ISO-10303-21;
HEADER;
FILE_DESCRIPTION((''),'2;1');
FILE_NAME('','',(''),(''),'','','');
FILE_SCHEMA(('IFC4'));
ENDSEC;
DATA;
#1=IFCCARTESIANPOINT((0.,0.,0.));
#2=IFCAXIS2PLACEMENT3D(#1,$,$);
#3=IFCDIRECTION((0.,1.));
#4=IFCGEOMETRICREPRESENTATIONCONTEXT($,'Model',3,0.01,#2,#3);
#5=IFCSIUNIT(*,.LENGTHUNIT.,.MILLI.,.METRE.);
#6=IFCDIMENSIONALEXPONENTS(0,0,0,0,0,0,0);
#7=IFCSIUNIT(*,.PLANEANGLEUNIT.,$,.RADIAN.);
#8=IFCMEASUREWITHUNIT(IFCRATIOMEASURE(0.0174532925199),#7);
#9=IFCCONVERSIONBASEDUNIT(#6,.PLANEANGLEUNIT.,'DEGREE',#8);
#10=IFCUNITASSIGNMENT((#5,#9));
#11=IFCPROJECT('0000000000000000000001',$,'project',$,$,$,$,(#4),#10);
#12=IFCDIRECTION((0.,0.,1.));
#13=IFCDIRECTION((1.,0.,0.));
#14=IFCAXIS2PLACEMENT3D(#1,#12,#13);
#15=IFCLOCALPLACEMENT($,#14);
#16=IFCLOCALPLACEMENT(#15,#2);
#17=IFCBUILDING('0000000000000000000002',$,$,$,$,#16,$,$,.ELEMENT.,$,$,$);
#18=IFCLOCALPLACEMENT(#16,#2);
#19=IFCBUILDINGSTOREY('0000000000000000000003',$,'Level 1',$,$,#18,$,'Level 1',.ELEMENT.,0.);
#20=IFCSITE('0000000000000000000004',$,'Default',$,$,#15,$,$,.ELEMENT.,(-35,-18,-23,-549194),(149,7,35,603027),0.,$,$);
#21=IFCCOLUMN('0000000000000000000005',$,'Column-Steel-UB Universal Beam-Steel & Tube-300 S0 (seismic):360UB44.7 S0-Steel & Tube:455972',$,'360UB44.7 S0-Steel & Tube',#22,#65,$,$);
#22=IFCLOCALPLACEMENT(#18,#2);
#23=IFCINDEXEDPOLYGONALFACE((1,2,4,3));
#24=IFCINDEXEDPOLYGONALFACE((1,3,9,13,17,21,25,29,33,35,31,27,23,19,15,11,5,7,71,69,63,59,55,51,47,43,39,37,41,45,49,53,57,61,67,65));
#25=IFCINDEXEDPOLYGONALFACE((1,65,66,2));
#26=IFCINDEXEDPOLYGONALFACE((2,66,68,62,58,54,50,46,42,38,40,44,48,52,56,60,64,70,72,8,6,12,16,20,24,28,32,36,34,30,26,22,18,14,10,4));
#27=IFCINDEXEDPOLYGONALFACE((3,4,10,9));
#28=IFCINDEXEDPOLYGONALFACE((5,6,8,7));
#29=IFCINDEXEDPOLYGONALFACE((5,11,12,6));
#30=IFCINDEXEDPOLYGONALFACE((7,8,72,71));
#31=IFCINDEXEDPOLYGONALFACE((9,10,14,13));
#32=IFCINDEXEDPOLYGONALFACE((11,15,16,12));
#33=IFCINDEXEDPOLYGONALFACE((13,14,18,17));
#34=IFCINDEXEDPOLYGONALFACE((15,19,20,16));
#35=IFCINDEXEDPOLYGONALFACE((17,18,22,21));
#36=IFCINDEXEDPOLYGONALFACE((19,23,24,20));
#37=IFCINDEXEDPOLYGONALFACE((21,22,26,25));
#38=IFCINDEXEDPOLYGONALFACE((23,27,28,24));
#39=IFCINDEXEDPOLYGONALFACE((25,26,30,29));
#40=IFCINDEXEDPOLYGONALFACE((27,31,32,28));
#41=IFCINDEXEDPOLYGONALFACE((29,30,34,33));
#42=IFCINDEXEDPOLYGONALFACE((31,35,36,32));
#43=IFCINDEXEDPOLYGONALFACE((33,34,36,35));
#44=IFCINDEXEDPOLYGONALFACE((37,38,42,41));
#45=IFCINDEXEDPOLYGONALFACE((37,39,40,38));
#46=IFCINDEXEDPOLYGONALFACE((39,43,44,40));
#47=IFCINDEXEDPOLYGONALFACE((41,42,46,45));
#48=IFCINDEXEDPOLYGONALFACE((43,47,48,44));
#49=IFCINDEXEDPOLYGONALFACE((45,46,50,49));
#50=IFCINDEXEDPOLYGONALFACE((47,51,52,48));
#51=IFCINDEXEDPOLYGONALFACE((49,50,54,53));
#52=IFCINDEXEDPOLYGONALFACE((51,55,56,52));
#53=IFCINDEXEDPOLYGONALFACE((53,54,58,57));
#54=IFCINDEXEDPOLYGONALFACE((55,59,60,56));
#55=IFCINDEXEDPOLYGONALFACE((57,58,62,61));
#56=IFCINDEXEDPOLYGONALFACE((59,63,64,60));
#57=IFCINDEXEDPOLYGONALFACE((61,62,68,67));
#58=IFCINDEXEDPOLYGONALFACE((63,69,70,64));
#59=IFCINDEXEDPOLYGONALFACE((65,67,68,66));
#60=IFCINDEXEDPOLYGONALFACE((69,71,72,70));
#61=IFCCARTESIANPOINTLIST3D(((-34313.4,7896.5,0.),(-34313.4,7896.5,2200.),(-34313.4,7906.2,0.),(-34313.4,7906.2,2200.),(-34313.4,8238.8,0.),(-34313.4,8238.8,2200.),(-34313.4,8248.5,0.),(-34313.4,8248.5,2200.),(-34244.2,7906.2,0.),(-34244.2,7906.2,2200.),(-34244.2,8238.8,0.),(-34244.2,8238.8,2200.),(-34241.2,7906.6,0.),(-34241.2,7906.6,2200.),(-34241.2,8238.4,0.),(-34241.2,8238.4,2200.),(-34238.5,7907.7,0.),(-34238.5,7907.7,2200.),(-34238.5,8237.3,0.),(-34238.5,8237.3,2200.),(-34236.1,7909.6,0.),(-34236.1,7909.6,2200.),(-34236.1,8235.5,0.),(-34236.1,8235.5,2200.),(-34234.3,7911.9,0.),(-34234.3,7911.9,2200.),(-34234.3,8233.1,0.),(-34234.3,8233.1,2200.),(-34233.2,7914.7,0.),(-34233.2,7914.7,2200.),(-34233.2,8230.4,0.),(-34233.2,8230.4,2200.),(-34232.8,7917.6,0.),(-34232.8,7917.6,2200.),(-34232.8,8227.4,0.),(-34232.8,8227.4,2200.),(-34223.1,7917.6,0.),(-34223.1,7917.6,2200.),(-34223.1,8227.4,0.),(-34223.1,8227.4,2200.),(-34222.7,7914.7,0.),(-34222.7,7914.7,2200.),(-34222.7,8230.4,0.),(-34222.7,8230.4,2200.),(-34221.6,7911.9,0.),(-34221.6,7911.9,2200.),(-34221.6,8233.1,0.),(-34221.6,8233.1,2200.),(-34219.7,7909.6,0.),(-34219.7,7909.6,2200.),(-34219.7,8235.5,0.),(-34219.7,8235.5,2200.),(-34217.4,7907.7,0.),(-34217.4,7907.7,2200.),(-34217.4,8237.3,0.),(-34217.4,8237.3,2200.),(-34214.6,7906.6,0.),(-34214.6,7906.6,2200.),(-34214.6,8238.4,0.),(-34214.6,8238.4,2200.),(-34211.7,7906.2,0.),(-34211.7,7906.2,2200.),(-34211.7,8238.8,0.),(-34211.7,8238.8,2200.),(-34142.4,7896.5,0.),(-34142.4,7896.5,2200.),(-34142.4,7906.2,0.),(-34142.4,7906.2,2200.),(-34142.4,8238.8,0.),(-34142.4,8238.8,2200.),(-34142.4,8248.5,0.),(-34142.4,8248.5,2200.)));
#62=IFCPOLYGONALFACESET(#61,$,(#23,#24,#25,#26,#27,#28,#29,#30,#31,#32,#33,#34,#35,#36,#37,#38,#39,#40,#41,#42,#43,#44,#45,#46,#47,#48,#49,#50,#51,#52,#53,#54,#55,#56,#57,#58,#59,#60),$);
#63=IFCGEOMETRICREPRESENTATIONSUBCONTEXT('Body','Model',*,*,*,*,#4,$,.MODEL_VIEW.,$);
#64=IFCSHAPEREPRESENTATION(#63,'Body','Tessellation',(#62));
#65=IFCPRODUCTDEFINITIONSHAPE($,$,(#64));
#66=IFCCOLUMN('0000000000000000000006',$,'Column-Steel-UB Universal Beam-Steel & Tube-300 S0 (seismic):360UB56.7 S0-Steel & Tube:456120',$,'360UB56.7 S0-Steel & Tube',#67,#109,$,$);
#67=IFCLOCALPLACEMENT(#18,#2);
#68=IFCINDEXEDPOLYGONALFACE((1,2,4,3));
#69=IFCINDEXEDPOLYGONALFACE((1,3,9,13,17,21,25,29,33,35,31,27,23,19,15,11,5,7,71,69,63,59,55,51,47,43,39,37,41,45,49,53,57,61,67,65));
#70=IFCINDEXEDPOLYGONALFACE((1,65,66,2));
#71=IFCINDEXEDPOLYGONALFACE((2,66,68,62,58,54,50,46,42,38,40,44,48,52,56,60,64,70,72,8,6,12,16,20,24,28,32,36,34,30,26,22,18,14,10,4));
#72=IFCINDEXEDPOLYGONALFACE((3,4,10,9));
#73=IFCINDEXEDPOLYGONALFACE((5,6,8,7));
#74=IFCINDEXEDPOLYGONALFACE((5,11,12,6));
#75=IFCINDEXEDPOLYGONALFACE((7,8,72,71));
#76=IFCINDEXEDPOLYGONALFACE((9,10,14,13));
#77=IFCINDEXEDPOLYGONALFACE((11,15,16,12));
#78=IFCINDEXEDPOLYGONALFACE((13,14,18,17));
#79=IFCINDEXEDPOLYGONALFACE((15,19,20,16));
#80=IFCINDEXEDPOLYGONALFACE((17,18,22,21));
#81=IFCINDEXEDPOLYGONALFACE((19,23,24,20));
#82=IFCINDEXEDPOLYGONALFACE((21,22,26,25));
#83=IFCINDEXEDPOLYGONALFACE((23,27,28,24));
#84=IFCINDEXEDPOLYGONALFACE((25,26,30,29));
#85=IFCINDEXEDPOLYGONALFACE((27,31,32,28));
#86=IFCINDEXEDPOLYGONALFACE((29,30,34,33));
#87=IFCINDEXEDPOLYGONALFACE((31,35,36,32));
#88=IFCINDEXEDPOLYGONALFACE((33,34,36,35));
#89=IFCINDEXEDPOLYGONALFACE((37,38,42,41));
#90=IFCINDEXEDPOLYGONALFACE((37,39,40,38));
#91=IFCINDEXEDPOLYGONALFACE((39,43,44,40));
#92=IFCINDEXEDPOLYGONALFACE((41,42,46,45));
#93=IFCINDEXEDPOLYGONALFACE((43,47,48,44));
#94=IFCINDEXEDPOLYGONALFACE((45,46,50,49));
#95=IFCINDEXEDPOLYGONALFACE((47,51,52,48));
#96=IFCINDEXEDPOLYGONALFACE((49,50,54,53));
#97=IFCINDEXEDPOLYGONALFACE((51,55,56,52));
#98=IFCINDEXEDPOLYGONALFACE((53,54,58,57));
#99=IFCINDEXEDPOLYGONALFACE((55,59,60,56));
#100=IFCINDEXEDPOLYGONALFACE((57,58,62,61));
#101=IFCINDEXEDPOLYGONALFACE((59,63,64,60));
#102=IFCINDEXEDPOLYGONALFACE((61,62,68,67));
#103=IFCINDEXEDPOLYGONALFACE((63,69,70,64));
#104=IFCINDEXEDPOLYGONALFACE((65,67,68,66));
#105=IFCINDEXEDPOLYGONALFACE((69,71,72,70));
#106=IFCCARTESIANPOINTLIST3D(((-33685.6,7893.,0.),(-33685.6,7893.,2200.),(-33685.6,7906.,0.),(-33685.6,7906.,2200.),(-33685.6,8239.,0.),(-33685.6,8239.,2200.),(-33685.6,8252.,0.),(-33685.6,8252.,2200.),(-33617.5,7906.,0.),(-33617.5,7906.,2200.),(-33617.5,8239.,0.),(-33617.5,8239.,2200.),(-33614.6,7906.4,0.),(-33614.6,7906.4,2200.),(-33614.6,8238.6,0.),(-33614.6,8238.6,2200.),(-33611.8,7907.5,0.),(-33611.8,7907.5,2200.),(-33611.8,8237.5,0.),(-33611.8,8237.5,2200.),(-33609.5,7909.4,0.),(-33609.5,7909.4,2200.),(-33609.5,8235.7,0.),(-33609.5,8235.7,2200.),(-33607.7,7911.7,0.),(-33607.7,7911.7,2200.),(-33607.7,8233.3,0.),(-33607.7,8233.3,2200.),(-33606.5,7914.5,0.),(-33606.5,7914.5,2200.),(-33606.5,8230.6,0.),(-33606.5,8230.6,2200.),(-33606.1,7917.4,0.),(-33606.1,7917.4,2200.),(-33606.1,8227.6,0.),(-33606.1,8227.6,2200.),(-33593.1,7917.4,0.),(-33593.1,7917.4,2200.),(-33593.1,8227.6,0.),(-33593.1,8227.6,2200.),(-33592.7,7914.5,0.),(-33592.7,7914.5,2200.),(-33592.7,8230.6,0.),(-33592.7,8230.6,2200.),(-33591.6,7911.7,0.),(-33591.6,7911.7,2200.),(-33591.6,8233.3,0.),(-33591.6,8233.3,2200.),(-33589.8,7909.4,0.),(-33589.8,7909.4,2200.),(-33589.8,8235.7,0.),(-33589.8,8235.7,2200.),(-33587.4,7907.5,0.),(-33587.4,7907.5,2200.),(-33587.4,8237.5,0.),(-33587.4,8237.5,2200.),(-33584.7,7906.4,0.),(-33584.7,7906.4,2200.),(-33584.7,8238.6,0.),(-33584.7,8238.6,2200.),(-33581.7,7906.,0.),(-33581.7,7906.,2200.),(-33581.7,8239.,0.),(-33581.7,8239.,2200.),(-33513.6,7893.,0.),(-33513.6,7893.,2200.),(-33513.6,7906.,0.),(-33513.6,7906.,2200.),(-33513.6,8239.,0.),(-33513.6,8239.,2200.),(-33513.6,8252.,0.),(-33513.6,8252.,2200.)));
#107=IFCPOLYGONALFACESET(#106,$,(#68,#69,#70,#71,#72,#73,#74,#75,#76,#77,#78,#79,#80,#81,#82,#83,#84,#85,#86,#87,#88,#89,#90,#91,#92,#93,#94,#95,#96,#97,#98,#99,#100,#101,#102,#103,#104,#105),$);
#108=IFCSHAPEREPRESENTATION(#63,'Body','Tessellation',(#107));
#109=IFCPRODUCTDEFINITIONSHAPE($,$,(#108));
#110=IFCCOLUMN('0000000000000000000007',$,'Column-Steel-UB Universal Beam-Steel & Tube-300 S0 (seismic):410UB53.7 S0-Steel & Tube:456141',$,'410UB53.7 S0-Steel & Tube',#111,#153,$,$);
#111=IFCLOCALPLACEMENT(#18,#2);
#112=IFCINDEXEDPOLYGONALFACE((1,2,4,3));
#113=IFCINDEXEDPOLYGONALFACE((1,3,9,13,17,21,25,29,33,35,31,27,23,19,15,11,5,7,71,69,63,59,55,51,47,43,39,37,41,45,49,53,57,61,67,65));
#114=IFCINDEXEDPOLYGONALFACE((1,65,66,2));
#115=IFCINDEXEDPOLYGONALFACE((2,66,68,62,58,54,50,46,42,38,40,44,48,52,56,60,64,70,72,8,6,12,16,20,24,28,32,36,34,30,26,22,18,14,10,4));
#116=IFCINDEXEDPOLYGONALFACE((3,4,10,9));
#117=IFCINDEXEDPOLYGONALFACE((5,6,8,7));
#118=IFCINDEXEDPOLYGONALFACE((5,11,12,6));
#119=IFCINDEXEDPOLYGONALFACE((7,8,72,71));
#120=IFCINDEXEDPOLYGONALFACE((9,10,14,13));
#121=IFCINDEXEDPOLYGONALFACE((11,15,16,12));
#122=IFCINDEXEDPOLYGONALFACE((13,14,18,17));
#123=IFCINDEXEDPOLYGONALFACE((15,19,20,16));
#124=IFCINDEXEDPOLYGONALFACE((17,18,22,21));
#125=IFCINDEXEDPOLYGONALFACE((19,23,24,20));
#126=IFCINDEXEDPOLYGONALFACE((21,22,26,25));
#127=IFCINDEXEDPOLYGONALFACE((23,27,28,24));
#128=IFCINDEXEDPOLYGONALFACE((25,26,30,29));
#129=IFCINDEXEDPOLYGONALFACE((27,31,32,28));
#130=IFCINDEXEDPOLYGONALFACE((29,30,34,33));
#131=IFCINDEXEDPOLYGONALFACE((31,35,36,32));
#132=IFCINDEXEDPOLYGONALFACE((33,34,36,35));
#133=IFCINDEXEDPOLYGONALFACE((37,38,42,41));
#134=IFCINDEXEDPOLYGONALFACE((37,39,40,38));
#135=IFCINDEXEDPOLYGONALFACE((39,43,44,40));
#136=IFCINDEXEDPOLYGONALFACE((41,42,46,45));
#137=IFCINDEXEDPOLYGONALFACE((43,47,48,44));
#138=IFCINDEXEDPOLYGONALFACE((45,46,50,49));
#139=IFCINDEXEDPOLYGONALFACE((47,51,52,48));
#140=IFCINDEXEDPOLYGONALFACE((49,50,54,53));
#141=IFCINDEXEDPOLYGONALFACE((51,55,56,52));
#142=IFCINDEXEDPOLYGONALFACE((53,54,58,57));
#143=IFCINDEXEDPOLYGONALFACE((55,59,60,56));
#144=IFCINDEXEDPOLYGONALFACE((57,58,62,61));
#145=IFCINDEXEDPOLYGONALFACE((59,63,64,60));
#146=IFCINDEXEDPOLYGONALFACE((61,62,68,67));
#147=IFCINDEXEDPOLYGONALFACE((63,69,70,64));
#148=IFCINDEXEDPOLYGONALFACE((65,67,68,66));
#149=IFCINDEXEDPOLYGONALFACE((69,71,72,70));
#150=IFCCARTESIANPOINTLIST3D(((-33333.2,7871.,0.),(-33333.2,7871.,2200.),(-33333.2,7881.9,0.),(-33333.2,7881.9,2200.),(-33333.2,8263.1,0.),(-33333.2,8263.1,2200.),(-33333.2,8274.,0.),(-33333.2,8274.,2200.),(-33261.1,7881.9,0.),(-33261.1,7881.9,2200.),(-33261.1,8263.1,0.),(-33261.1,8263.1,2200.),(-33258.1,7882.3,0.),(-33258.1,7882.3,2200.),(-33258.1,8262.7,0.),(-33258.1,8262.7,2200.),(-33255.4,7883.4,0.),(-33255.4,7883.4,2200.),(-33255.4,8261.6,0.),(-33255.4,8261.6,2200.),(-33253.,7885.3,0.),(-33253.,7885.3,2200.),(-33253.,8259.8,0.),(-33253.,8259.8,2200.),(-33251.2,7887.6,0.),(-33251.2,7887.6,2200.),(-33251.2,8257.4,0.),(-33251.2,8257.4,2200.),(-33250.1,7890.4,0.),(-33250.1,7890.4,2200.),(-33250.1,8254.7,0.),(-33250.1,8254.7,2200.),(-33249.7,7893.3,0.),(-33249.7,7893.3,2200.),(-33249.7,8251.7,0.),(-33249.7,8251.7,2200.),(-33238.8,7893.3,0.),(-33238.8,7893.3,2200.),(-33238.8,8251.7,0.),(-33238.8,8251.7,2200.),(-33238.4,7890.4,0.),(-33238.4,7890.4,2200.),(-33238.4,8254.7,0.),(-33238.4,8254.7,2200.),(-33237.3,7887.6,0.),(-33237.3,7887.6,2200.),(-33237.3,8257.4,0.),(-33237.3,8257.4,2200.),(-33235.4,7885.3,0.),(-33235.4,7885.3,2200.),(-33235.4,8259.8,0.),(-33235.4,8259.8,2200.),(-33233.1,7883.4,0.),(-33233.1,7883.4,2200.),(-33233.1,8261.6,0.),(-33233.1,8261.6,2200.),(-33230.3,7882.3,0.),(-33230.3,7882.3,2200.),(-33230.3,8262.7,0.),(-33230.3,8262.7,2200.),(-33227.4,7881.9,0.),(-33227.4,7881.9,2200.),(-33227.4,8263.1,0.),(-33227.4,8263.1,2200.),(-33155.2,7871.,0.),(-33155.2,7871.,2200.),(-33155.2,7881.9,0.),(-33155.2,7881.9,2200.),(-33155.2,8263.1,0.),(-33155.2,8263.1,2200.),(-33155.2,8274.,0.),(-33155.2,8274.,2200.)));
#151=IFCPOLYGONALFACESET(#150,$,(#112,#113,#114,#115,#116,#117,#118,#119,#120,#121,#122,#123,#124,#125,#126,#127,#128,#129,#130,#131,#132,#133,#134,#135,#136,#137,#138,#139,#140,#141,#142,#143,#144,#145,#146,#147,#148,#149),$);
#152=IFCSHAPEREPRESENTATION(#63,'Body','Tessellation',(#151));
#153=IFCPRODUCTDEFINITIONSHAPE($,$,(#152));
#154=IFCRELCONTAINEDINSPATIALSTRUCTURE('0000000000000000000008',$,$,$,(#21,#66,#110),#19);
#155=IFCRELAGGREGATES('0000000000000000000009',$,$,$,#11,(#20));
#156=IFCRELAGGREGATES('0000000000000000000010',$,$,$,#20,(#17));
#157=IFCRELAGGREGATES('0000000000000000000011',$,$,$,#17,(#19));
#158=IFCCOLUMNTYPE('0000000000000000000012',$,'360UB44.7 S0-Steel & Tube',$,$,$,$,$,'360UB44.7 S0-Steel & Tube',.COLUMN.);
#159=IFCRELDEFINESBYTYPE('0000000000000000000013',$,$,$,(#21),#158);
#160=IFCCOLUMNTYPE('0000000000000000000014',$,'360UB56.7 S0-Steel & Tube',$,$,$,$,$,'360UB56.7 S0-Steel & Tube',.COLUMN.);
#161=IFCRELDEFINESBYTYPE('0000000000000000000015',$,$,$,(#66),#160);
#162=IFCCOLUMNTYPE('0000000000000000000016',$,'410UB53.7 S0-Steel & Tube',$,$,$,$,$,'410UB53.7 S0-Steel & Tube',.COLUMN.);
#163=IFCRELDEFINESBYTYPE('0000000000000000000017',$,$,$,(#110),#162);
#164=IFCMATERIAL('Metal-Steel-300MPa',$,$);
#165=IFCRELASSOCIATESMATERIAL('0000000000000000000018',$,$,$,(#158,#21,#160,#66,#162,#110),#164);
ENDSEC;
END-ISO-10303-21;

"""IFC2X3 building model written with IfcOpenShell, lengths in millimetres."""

from ifc_helpers import new_model, entity, si_unit, converted_unit, direction, frame, frame_2d, origin, origin_with_axes, place, context, subcontext, project, spatial, polyline, circle_curve, parameter, trimmed, segment, composite_curve, outline, extrude, source, transform, mapped, material, type_object, type_shapes, element, save


model = new_model("IFC2X3")

# Units and contexts
model_context = context("Model", 3, precision=0.01, world=origin(), true_north=direction((0.0, 1.0)))
body_context = subcontext(model_context, "Body", "Model", "MODEL_VIEW")
ifc_project = project(units=[si_unit("LENGTHUNIT", "METRE", prefix="MILLI"), converted_unit("PLANEANGLEUNIT", "DEGREE", entity("IfcRatioMeasure", 0.0174532925199), si_unit("PLANEANGLEUNIT", "RADIAN"), dimensions=[0, 0, 0, 0, 0, 0, 0])], contexts=[model_context])

# Site, building, storey
site_placement = place(None, origin_with_axes())
site = spatial("IfcSite", under=ifc_project, at=site_placement, Name="Default", CompositionType="ELEMENT", RefLatitude=(-35, -18, -23, -549194), RefLongitude=(149, 7, 35, 603027), RefElevation=0.0)
building_placement = place(site_placement, origin())
building = spatial("IfcBuilding", under=site, at=building_placement, CompositionType="ELEMENT")
storey_placement = place(building_placement, origin())
storey = spatial("IfcBuildingStorey", under=building, at=storey_placement, Name="Level 1", LongName="Level 1", CompositionType="ELEMENT", Elevation=0.0)

# Columns
ifc_material = material(Name="Metal-Steel-300MPa")
column_type_1 = type_object("IfcColumnType", Name="360UB44.7 S0-Steel & Tube", ElementType="360UB44.7 S0-Steel & Tube", PredefinedType="COLUMN", material=ifc_material)
shared_shape_1 = source(origin(), body_context, "Body", "SweptSolid", [
    extrude(outline(composite_curve([segment(polyline([(166.3, -85.5), (176.0, -85.5)]), True, "CONTINUOUS"), segment(polyline([(176.0, -85.5), (176.0, 85.5)]), True, "CONTINUOUS"), segment(polyline([(176.0, 85.5), (166.3, 85.5)]), True, "CONTINUOUS"), segment(polyline([(166.3, 85.5), (166.3, 16.2)]), True, "CONTINUOUS"), segment(trimmed(circle_curve(frame_2d((154.9, 16.2), x_axis=(1.0, 0.0)), 11.4), [parameter(270.0)], [parameter(0.0)], True, "PARAMETER"), False, "CONTINUOUS"), segment(polyline([(154.9, 4.8), (-154.9, 4.8)]), True, "CONTINUOUS"), segment(trimmed(circle_curve(frame_2d((-154.9, 16.2), x_axis=(0.0, -1.0)), 11.4), [parameter(270.0)], [parameter(0.0)], True, "PARAMETER"), False, "CONTINUOUS"), segment(polyline([(-166.3, 16.2), (-166.3, 85.5)]), True, "CONTINUOUS"), segment(polyline([(-166.3, 85.5), (-176.0, 85.5)]), True, "CONTINUOUS"), segment(polyline([(-176.0, 85.5), (-176.0, -85.5)]), True, "CONTINUOUS"), segment(polyline([(-176.0, -85.5), (-166.3, -85.5)]), True, "CONTINUOUS"), segment(polyline([(-166.3, -85.5), (-166.3, -16.2)]), True, "CONTINUOUS"), segment(trimmed(circle_curve(frame_2d((-154.9, -16.2), x_axis=(-1.0, 0.0)), 11.4), [parameter(270.0)], [parameter(0.0)], True, "PARAMETER"), False, "CONTINUOUS"), segment(polyline([(-154.9, -4.8), (154.9, -4.8)]), True, "CONTINUOUS"), segment(trimmed(circle_curve(frame_2d((154.9, -16.2), x_axis=(0.0, 1.0)), 11.4), [parameter(270.0)], [parameter(0.0)], True, "PARAMETER"), False, "CONTINUOUS"), segment(polyline([(166.3, -16.2), (166.3, -85.5)]), True, "CONTINUOUS")], self_intersect=False)), frame((0.0, 0.0, 0.0), z_axis=(0.0, 0.0, 1.0), x_axis=(0.0, -1.0, 0.0)), (0.0, 0.0, 1.0), 2200.0),
])
type_shapes(column_type_1, [shared_shape_1])
column_1_placement = place(storey_placement, frame((-34227.9, 8072.5, 0.0)))
element("IfcColumn", 1, at=column_1_placement, inside=storey, type_object=column_type_1, material=ifc_material, Name="Column-Steel-UB Universal Beam-Steel & Tube-300 S0 (seismic):360UB44.7 S0-Steel & Tube:455972", ObjectType="360UB44.7 S0-Steel & Tube", context=body_context, shape_type="MappedRepresentation", body=[
    mapped(shared_shape_1, transform((0.0, 0.0, 0.0), scale=1.0)),
])
column_type_2 = type_object("IfcColumnType", Name="360UB56.7 S0-Steel & Tube", ElementType="360UB56.7 S0-Steel & Tube", PredefinedType="COLUMN", material=ifc_material)
shared_shape_2 = source(origin(), body_context, "Body", "SweptSolid", [
    extrude(outline(composite_curve([segment(polyline([(166.5, -86.0), (179.5, -86.0)]), True, "CONTINUOUS"), segment(polyline([(179.5, -86.0), (179.5, 86.0)]), True, "CONTINUOUS"), segment(polyline([(179.5, 86.0), (166.5, 86.0)]), True, "CONTINUOUS"), segment(polyline([(166.5, 86.0), (166.5, 17.9)]), True, "CONTINUOUS"), segment(trimmed(circle_curve(frame_2d((155.1, 17.9), x_axis=(1.0, 0.0)), 11.4), [parameter(270.0)], [parameter(0.0)], True, "PARAMETER"), False, "CONTINUOUS"), segment(polyline([(155.1, 6.5), (-155.1, 6.5)]), True, "CONTINUOUS"), segment(trimmed(circle_curve(frame_2d((-155.1, 17.9), x_axis=(0.0, -1.0)), 11.4), [parameter(270.0)], [parameter(0.0)], True, "PARAMETER"), False, "CONTINUOUS"), segment(polyline([(-166.5, 17.9), (-166.5, 86.0)]), True, "CONTINUOUS"), segment(polyline([(-166.5, 86.0), (-179.5, 86.0)]), True, "CONTINUOUS"), segment(polyline([(-179.5, 86.0), (-179.5, -86.0)]), True, "CONTINUOUS"), segment(polyline([(-179.5, -86.0), (-166.5, -86.0)]), True, "CONTINUOUS"), segment(polyline([(-166.5, -86.0), (-166.5, -17.9)]), True, "CONTINUOUS"), segment(trimmed(circle_curve(frame_2d((-155.1, -17.9), x_axis=(-1.0, 0.0)), 11.4), [parameter(270.0)], [parameter(0.0)], True, "PARAMETER"), False, "CONTINUOUS"), segment(polyline([(-155.1, -6.5), (155.1, -6.5)]), True, "CONTINUOUS"), segment(trimmed(circle_curve(frame_2d((155.1, -17.9), x_axis=(0.0, 1.0)), 11.4), [parameter(270.0)], [parameter(0.0)], True, "PARAMETER"), False, "CONTINUOUS"), segment(polyline([(166.5, -17.9), (166.5, -86.0)]), True, "CONTINUOUS")], self_intersect=False)), frame((0.0, 0.0, 0.0), z_axis=(0.0, 0.0, 1.0), x_axis=(0.0, -1.0, 0.0)), (0.0, 0.0, 1.0), 2200.0),
])
type_shapes(column_type_2, [shared_shape_2])
column_2_placement = place(storey_placement, frame((-33599.6, 8072.5, 0.0)))
element("IfcColumn", 2, at=column_2_placement, inside=storey, type_object=column_type_2, material=ifc_material, Name="Column-Steel-UB Universal Beam-Steel & Tube-300 S0 (seismic):360UB56.7 S0-Steel & Tube:456120", ObjectType="360UB56.7 S0-Steel & Tube", context=body_context, shape_type="MappedRepresentation", body=[
    mapped(shared_shape_2, transform((0.0, 0.0, 0.0), scale=1.0)),
])
column_type_3 = type_object("IfcColumnType", Name="410UB53.7 S0-Steel & Tube", ElementType="410UB53.7 S0-Steel & Tube", PredefinedType="COLUMN", material=ifc_material)
shared_shape_3 = source(origin(), body_context, "Body", "SweptSolid", [
    extrude(outline(composite_curve([segment(polyline([(190.6, -89.0), (201.5, -89.0)]), True, "CONTINUOUS"), segment(polyline([(201.5, -89.0), (201.5, 89.0)]), True, "CONTINUOUS"), segment(polyline([(201.5, 89.0), (190.6, 89.0)]), True, "CONTINUOUS"), segment(polyline([(190.6, 89.0), (190.6, 16.9)]), True, "CONTINUOUS"), segment(trimmed(circle_curve(frame_2d((179.2, 16.9), x_axis=(1.0, 0.0)), 11.4), [parameter(270.0)], [parameter(0.0)], True, "PARAMETER"), False, "CONTINUOUS"), segment(polyline([(179.2, 5.5), (-179.2, 5.5)]), True, "CONTINUOUS"), segment(trimmed(circle_curve(frame_2d((-179.2, 16.9), x_axis=(0.0, -1.0)), 11.4), [parameter(270.0)], [parameter(0.0)], True, "PARAMETER"), False, "CONTINUOUS"), segment(polyline([(-190.6, 16.9), (-190.6, 89.0)]), True, "CONTINUOUS"), segment(polyline([(-190.6, 89.0), (-201.5, 89.0)]), True, "CONTINUOUS"), segment(polyline([(-201.5, 89.0), (-201.5, -89.0)]), True, "CONTINUOUS"), segment(polyline([(-201.5, -89.0), (-190.6, -89.0)]), True, "CONTINUOUS"), segment(polyline([(-190.6, -89.0), (-190.6, -16.9)]), True, "CONTINUOUS"), segment(trimmed(circle_curve(frame_2d((-179.2, -16.9), x_axis=(-1.0, 0.0)), 11.4), [parameter(270.0)], [parameter(0.0)], True, "PARAMETER"), False, "CONTINUOUS"), segment(polyline([(-179.2, -5.5), (179.2, -5.5)]), True, "CONTINUOUS"), segment(trimmed(circle_curve(frame_2d((179.2, -16.9), x_axis=(0.0, 1.0)), 11.4), [parameter(270.0)], [parameter(0.0)], True, "PARAMETER"), False, "CONTINUOUS"), segment(polyline([(190.6, -16.9), (190.6, -89.0)]), True, "CONTINUOUS")], self_intersect=False)), frame((0.0, 0.0, 0.0), z_axis=(0.0, 0.0, 1.0), x_axis=(0.0, -1.0, 0.0)), (0.0, 0.0, 1.0), 2200.0),
])
type_shapes(column_type_3, [shared_shape_3])
column_3_placement = place(storey_placement, frame((-33244.2, 8072.5, 0.0)))
element("IfcColumn", 3, at=column_3_placement, inside=storey, type_object=column_type_3, material=ifc_material, Name="Column-Steel-UB Universal Beam-Steel & Tube-300 S0 (seismic):410UB53.7 S0-Steel & Tube:456141", ObjectType="410UB53.7 S0-Steel & Tube", context=body_context, shape_type="MappedRepresentation", body=[
    mapped(shared_shape_3, transform((0.0, 0.0, 0.0), scale=1.0)),
])

save(model, "model.ifc")
